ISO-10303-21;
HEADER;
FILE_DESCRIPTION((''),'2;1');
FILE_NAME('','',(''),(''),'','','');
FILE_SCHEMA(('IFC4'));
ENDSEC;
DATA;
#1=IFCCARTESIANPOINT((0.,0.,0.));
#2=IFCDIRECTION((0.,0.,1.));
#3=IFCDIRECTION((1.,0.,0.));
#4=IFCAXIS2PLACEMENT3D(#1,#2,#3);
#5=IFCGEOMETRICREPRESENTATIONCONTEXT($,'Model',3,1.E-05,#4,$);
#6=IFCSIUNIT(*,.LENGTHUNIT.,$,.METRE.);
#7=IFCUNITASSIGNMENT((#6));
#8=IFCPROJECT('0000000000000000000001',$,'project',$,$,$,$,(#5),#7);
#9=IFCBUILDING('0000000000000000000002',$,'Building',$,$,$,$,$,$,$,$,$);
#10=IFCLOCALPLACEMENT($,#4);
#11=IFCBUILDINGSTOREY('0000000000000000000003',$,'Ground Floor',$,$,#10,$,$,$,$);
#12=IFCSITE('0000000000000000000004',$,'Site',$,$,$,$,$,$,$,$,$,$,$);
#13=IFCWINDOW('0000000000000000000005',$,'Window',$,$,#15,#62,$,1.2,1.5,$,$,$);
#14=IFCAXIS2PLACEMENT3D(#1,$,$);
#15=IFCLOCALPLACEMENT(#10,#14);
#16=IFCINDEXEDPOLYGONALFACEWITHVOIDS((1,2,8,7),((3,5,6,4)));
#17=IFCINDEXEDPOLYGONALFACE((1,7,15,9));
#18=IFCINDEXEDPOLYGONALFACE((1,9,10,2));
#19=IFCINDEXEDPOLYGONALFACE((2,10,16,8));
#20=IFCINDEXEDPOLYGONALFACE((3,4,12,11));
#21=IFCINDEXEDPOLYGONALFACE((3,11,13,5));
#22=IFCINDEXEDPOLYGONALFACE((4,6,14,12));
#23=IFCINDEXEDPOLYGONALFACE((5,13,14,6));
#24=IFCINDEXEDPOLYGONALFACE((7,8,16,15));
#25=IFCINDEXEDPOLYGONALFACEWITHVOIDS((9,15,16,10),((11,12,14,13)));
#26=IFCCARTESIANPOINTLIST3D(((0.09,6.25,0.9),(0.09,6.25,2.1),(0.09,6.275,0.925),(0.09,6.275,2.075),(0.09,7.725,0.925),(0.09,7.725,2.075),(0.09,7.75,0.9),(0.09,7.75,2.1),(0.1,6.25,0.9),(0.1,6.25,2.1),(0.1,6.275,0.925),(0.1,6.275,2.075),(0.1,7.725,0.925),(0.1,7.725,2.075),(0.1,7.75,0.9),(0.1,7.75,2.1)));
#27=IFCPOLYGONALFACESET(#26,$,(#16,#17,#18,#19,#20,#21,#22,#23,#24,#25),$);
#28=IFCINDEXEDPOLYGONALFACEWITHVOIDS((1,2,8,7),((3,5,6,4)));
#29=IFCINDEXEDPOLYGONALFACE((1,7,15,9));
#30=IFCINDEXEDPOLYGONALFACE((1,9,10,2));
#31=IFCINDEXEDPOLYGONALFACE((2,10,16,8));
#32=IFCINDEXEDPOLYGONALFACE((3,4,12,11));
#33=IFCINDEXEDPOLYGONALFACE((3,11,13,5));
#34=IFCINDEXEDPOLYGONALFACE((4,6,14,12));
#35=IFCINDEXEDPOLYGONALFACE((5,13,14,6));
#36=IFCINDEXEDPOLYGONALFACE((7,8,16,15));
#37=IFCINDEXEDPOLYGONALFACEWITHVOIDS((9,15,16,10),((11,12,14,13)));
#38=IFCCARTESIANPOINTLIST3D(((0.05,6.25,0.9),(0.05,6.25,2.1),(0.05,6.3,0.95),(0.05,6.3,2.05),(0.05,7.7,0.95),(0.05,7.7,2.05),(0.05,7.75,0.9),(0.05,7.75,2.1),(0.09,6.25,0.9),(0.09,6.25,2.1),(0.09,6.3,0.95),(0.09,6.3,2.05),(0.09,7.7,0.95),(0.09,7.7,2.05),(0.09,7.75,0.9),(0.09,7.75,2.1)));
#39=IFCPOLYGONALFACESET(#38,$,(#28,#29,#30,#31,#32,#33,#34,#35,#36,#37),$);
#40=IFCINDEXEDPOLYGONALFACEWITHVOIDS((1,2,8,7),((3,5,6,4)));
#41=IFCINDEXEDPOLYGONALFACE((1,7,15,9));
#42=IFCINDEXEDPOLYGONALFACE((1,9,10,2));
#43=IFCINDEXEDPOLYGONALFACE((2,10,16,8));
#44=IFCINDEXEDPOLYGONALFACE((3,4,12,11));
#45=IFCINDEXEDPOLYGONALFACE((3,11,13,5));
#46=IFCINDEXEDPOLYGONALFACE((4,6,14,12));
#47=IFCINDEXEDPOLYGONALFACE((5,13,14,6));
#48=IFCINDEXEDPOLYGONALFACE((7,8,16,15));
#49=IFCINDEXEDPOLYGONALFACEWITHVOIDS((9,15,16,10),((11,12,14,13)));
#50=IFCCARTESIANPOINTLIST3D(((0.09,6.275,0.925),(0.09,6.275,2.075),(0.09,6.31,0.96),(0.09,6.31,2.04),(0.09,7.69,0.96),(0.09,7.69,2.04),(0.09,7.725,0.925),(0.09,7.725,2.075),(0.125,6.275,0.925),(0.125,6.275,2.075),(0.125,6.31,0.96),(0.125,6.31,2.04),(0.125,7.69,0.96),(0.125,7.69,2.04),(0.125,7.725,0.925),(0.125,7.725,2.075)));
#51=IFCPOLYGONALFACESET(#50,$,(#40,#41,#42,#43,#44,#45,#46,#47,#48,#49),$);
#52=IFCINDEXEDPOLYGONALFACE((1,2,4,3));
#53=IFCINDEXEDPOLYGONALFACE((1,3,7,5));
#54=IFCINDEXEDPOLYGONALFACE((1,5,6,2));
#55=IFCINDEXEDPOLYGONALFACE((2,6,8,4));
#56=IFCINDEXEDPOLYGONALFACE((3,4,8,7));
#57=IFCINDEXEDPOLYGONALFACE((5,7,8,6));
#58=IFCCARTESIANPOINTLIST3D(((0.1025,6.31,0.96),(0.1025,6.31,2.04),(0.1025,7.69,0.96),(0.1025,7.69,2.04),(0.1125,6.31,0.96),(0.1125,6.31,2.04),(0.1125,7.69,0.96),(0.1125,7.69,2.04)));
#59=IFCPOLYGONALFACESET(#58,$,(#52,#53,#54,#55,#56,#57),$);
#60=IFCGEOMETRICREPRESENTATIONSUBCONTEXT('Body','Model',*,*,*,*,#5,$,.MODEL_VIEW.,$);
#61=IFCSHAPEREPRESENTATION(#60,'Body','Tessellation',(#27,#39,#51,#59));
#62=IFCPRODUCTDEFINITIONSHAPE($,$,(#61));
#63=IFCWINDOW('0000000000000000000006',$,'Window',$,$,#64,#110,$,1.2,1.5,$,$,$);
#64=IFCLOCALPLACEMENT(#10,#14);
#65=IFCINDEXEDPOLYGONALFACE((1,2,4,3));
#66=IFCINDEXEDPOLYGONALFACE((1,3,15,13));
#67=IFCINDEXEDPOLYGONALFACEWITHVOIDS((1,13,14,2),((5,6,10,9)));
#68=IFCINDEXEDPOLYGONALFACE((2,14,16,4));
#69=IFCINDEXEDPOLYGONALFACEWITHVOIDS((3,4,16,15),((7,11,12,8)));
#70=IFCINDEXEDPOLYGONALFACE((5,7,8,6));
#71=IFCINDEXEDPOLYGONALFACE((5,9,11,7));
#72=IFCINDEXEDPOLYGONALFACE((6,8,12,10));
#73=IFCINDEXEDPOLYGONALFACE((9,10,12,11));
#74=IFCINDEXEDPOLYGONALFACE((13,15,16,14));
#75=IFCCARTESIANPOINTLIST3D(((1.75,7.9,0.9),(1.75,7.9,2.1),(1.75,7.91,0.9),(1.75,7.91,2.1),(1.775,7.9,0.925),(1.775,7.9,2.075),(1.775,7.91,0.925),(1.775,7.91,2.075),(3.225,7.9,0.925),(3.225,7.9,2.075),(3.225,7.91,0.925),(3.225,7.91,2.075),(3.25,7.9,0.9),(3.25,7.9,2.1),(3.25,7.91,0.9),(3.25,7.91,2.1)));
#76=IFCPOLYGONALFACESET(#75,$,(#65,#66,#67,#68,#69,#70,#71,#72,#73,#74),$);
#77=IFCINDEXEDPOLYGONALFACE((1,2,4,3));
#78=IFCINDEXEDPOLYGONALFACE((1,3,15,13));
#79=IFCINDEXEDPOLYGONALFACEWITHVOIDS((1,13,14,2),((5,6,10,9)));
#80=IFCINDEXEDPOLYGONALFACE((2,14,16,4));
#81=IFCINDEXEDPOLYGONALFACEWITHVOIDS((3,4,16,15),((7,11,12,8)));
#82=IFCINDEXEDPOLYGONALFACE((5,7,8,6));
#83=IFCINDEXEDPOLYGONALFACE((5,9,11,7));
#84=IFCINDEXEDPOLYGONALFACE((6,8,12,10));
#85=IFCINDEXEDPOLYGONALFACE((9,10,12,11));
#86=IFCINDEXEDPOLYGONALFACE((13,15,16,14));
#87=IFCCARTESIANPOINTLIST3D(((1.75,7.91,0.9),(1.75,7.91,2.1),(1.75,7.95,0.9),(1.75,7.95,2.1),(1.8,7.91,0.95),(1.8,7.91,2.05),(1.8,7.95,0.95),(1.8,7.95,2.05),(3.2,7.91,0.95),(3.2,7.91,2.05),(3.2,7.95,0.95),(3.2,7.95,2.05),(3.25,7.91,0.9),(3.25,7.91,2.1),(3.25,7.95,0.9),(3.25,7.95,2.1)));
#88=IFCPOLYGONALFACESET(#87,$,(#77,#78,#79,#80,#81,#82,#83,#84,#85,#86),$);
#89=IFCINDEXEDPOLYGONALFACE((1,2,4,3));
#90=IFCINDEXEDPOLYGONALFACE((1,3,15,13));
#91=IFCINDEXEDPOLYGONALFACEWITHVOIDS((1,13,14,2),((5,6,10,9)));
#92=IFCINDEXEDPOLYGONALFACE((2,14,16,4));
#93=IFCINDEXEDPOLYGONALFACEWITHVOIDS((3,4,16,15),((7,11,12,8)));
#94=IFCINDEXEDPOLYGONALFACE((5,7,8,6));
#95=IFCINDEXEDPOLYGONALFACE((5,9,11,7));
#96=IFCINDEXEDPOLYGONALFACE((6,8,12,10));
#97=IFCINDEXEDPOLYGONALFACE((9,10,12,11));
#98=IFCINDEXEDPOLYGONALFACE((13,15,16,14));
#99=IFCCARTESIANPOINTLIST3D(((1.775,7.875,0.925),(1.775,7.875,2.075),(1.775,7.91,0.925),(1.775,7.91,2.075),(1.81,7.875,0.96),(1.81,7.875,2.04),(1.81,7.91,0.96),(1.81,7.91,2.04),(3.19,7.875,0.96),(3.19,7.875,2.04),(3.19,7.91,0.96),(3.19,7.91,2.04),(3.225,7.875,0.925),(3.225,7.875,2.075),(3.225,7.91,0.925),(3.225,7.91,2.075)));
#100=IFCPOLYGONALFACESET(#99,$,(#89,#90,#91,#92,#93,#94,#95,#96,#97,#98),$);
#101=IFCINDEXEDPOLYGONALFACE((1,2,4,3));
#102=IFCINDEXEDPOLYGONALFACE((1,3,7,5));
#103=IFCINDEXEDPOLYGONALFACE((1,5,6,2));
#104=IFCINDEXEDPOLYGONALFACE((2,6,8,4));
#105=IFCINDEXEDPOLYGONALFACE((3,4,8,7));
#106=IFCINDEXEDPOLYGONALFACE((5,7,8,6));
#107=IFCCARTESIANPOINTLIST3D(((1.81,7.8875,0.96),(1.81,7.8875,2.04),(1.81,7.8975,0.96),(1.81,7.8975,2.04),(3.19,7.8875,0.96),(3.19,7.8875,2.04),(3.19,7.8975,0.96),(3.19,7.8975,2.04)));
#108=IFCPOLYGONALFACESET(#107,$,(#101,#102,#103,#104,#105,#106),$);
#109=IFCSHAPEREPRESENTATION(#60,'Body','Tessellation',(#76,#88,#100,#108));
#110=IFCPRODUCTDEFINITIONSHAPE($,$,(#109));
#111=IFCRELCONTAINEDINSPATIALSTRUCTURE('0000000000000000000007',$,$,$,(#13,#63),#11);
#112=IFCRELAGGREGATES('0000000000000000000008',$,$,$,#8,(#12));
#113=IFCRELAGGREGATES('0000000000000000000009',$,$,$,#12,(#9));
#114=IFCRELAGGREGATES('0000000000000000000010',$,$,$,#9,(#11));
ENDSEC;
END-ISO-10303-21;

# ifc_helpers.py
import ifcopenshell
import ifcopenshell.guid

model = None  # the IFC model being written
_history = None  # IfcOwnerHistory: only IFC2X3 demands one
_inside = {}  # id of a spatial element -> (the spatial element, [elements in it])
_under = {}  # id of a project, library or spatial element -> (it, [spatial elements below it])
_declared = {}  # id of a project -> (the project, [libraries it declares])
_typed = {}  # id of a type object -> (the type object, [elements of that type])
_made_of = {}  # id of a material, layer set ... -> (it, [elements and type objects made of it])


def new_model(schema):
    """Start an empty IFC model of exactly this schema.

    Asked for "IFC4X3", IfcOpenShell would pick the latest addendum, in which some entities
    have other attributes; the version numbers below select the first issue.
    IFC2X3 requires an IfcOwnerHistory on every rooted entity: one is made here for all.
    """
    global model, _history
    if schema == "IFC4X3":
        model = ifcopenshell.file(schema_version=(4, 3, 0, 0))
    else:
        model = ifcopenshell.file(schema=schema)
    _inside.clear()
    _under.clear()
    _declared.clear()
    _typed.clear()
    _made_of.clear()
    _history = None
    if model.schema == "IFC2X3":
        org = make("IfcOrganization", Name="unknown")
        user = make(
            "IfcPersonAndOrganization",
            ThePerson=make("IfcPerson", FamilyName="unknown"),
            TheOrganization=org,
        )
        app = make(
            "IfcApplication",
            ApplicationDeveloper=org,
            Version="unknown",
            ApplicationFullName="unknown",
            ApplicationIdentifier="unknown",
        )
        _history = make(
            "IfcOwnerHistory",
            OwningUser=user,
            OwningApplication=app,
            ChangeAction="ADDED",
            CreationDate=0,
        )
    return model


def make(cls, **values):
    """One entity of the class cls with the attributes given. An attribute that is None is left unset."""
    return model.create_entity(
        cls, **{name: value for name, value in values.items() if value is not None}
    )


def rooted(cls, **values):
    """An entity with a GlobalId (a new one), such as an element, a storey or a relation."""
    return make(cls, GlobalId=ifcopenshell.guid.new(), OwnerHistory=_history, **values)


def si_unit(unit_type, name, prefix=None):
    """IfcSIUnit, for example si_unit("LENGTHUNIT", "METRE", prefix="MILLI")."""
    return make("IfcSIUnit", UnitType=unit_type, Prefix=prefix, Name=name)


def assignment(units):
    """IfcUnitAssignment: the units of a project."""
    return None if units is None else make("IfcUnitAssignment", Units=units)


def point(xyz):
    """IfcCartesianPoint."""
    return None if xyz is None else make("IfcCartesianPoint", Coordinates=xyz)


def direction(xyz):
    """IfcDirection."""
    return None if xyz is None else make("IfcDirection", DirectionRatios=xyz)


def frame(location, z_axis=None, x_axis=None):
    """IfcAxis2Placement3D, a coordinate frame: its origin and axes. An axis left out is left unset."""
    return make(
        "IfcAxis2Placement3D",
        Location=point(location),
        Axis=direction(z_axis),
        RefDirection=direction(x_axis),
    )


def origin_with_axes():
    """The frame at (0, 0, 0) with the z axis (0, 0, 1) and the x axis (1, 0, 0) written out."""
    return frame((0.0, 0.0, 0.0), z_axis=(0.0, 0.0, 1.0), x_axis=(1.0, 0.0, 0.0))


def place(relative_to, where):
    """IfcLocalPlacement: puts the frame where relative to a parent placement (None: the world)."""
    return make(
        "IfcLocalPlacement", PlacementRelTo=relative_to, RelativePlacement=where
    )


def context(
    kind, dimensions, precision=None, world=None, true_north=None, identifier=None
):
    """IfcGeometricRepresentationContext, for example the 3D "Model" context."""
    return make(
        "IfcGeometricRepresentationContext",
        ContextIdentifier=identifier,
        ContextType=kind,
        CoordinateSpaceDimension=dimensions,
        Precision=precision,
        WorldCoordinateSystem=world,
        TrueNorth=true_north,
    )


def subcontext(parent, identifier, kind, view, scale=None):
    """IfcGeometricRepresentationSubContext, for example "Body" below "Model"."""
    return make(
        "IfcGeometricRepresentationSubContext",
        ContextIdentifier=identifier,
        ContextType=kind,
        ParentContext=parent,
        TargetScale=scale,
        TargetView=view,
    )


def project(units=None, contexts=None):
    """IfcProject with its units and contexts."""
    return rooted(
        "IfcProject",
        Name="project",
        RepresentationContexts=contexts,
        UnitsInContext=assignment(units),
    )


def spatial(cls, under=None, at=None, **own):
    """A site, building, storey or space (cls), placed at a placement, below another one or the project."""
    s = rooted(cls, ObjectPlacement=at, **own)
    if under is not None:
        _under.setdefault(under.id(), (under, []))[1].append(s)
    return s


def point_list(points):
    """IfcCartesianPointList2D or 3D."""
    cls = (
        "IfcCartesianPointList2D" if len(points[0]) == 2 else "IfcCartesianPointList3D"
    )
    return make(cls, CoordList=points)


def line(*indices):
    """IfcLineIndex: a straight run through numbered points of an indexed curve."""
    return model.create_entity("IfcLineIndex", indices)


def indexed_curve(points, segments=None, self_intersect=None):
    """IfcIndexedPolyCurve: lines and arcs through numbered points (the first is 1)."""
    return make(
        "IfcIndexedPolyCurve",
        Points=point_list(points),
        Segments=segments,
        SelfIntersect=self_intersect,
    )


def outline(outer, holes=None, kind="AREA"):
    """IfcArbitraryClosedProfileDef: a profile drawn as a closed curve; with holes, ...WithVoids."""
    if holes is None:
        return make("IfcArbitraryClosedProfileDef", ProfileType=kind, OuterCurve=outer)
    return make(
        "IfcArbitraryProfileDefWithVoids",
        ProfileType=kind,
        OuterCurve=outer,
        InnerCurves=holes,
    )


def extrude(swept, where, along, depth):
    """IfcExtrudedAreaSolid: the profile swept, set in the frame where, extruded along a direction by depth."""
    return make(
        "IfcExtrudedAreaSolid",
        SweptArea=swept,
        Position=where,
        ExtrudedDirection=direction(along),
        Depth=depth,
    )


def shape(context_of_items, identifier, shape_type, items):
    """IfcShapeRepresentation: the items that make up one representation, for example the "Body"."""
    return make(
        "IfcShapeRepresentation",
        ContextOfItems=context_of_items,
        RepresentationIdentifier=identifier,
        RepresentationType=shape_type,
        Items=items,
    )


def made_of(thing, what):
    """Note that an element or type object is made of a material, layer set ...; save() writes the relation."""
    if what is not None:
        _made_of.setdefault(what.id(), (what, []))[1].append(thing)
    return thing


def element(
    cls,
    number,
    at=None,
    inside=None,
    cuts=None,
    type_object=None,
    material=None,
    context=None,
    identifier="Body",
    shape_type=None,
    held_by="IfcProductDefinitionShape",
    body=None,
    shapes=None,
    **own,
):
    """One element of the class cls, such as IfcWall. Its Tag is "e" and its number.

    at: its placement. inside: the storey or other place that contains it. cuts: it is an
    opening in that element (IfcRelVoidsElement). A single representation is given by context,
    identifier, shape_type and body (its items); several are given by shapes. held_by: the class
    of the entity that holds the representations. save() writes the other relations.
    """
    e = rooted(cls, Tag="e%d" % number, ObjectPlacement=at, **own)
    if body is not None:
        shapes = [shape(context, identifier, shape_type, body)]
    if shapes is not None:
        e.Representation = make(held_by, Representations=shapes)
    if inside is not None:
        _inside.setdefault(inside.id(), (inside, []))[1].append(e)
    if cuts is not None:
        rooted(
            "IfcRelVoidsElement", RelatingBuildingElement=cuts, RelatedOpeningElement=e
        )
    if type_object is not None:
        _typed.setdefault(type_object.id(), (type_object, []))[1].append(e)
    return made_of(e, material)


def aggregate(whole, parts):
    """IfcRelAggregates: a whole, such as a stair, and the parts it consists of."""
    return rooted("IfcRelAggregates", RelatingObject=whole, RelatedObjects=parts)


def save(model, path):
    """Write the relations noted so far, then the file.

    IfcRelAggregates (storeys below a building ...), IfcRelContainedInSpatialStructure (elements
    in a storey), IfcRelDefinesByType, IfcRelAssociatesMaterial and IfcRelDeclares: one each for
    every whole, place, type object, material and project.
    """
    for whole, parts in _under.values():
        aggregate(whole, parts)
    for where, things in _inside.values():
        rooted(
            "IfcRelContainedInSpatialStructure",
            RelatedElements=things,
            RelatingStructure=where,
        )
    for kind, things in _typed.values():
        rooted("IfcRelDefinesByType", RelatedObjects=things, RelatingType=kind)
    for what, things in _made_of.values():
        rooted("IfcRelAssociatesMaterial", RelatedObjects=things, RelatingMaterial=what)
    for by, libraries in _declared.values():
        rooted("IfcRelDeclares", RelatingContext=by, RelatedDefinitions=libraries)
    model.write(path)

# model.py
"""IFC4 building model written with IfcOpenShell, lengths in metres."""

from ifc_helpers import new_model, si_unit, frame, origin_with_axes, place, context, subcontext, project, spatial, line, indexed_curve, outline, extrude, element, save


model = new_model("IFC4")

# Units and contexts
model_context = context("Model", 3, precision=1e-05, world=origin_with_axes())
body_context = subcontext(model_context, "Body", "Model", "MODEL_VIEW")
ifc_project = project(units=[si_unit("LENGTHUNIT", "METRE")], contexts=[model_context])

# Site, building, storey
site = spatial("IfcSite", under=ifc_project, Name="Site")
building = spatial("IfcBuilding", under=site, Name="Building")
storey_placement = place(None, origin_with_axes())
storey = spatial("IfcBuildingStorey", under=building, at=storey_placement, Name="Ground Floor")

# Windows
for number, where, z_axis, x_axis, name in (
    (1, (0.0, 7.75, 0.9), (0.0, 0.0, 1.0), (0.0, -1.0, 0.0), "Window"),
    (2, (3.25, 8.0, 0.9), (0.0, 0.0, 1.0), (-1.0, 0.0, 0.0), "Window"),
):
    element("IfcWindow", number, at=place(storey_placement, frame(where, z_axis=z_axis, x_axis=x_axis)), inside=storey, Name=name, OverallHeight=1.2, OverallWidth=1.5, context=body_context, shape_type="SweptSolid", body=[
        extrude(outline(indexed_curve([(0.0, 0.0), (1.5, 0.0), (1.5, 1.2), (0.0, 1.2)], segments=[line(1, 2, 3, 4, 1)]), holes=[indexed_curve([(0.025, 0.025), (1.475, 0.025), (1.475, 1.175), (0.025, 1.175)], segments=[line(1, 2, 3, 4, 1)])]), frame((0.0, 0.09, 0.0), z_axis=(0.0, -1.0, 0.0), x_axis=(1.0, 0.0, 0.0)), (0.0, 0.0, -1.0), 0.01),
        extrude(outline(indexed_curve([(0.0, 0.0), (1.5, 0.0), (1.5, 1.2), (0.0, 1.2)], segments=[line(1, 2, 3, 4, 1)]), holes=[indexed_curve([(0.05, 0.05), (1.45, 0.05), (1.45, 1.15), (0.05, 1.15)], segments=[line(1, 2, 3, 4, 1)])]), frame((0.0, 0.05, 0.0), z_axis=(0.0, -1.0, 0.0), x_axis=(1.0, 0.0, 0.0)), (0.0, 0.0, -1.0), 0.04),
        extrude(outline(indexed_curve([(0.0, 0.0), (1.45, 0.0), (1.45, 1.15), (0.0, 1.15)], segments=[line(1, 2, 3, 4, 1)]), holes=[indexed_curve([(0.035, 0.035), (1.415, 0.035), (1.415, 1.115), (0.035, 1.115)], segments=[line(1, 2, 3, 4, 1)])]), frame((0.025, 0.09, 0.025), z_axis=(0.0, -1.0, 0.0), x_axis=(1.0, 0.0, 0.0)), (0.0, 0.0, -1.0), 0.035),
        extrude(outline(indexed_curve([(0.035, 0.035), (1.415, 0.035), (1.415, 1.115), (0.035, 1.115)], segments=[line(1, 2, 3, 4, 1)])), frame((0.025, 0.1025, 0.025), z_axis=(0.0, -1.0, 0.0), x_axis=(1.0, 0.0, 0.0)), (0.0, 0.0, -1.0), 0.01),
    ])

save(model, "model.ifc")
